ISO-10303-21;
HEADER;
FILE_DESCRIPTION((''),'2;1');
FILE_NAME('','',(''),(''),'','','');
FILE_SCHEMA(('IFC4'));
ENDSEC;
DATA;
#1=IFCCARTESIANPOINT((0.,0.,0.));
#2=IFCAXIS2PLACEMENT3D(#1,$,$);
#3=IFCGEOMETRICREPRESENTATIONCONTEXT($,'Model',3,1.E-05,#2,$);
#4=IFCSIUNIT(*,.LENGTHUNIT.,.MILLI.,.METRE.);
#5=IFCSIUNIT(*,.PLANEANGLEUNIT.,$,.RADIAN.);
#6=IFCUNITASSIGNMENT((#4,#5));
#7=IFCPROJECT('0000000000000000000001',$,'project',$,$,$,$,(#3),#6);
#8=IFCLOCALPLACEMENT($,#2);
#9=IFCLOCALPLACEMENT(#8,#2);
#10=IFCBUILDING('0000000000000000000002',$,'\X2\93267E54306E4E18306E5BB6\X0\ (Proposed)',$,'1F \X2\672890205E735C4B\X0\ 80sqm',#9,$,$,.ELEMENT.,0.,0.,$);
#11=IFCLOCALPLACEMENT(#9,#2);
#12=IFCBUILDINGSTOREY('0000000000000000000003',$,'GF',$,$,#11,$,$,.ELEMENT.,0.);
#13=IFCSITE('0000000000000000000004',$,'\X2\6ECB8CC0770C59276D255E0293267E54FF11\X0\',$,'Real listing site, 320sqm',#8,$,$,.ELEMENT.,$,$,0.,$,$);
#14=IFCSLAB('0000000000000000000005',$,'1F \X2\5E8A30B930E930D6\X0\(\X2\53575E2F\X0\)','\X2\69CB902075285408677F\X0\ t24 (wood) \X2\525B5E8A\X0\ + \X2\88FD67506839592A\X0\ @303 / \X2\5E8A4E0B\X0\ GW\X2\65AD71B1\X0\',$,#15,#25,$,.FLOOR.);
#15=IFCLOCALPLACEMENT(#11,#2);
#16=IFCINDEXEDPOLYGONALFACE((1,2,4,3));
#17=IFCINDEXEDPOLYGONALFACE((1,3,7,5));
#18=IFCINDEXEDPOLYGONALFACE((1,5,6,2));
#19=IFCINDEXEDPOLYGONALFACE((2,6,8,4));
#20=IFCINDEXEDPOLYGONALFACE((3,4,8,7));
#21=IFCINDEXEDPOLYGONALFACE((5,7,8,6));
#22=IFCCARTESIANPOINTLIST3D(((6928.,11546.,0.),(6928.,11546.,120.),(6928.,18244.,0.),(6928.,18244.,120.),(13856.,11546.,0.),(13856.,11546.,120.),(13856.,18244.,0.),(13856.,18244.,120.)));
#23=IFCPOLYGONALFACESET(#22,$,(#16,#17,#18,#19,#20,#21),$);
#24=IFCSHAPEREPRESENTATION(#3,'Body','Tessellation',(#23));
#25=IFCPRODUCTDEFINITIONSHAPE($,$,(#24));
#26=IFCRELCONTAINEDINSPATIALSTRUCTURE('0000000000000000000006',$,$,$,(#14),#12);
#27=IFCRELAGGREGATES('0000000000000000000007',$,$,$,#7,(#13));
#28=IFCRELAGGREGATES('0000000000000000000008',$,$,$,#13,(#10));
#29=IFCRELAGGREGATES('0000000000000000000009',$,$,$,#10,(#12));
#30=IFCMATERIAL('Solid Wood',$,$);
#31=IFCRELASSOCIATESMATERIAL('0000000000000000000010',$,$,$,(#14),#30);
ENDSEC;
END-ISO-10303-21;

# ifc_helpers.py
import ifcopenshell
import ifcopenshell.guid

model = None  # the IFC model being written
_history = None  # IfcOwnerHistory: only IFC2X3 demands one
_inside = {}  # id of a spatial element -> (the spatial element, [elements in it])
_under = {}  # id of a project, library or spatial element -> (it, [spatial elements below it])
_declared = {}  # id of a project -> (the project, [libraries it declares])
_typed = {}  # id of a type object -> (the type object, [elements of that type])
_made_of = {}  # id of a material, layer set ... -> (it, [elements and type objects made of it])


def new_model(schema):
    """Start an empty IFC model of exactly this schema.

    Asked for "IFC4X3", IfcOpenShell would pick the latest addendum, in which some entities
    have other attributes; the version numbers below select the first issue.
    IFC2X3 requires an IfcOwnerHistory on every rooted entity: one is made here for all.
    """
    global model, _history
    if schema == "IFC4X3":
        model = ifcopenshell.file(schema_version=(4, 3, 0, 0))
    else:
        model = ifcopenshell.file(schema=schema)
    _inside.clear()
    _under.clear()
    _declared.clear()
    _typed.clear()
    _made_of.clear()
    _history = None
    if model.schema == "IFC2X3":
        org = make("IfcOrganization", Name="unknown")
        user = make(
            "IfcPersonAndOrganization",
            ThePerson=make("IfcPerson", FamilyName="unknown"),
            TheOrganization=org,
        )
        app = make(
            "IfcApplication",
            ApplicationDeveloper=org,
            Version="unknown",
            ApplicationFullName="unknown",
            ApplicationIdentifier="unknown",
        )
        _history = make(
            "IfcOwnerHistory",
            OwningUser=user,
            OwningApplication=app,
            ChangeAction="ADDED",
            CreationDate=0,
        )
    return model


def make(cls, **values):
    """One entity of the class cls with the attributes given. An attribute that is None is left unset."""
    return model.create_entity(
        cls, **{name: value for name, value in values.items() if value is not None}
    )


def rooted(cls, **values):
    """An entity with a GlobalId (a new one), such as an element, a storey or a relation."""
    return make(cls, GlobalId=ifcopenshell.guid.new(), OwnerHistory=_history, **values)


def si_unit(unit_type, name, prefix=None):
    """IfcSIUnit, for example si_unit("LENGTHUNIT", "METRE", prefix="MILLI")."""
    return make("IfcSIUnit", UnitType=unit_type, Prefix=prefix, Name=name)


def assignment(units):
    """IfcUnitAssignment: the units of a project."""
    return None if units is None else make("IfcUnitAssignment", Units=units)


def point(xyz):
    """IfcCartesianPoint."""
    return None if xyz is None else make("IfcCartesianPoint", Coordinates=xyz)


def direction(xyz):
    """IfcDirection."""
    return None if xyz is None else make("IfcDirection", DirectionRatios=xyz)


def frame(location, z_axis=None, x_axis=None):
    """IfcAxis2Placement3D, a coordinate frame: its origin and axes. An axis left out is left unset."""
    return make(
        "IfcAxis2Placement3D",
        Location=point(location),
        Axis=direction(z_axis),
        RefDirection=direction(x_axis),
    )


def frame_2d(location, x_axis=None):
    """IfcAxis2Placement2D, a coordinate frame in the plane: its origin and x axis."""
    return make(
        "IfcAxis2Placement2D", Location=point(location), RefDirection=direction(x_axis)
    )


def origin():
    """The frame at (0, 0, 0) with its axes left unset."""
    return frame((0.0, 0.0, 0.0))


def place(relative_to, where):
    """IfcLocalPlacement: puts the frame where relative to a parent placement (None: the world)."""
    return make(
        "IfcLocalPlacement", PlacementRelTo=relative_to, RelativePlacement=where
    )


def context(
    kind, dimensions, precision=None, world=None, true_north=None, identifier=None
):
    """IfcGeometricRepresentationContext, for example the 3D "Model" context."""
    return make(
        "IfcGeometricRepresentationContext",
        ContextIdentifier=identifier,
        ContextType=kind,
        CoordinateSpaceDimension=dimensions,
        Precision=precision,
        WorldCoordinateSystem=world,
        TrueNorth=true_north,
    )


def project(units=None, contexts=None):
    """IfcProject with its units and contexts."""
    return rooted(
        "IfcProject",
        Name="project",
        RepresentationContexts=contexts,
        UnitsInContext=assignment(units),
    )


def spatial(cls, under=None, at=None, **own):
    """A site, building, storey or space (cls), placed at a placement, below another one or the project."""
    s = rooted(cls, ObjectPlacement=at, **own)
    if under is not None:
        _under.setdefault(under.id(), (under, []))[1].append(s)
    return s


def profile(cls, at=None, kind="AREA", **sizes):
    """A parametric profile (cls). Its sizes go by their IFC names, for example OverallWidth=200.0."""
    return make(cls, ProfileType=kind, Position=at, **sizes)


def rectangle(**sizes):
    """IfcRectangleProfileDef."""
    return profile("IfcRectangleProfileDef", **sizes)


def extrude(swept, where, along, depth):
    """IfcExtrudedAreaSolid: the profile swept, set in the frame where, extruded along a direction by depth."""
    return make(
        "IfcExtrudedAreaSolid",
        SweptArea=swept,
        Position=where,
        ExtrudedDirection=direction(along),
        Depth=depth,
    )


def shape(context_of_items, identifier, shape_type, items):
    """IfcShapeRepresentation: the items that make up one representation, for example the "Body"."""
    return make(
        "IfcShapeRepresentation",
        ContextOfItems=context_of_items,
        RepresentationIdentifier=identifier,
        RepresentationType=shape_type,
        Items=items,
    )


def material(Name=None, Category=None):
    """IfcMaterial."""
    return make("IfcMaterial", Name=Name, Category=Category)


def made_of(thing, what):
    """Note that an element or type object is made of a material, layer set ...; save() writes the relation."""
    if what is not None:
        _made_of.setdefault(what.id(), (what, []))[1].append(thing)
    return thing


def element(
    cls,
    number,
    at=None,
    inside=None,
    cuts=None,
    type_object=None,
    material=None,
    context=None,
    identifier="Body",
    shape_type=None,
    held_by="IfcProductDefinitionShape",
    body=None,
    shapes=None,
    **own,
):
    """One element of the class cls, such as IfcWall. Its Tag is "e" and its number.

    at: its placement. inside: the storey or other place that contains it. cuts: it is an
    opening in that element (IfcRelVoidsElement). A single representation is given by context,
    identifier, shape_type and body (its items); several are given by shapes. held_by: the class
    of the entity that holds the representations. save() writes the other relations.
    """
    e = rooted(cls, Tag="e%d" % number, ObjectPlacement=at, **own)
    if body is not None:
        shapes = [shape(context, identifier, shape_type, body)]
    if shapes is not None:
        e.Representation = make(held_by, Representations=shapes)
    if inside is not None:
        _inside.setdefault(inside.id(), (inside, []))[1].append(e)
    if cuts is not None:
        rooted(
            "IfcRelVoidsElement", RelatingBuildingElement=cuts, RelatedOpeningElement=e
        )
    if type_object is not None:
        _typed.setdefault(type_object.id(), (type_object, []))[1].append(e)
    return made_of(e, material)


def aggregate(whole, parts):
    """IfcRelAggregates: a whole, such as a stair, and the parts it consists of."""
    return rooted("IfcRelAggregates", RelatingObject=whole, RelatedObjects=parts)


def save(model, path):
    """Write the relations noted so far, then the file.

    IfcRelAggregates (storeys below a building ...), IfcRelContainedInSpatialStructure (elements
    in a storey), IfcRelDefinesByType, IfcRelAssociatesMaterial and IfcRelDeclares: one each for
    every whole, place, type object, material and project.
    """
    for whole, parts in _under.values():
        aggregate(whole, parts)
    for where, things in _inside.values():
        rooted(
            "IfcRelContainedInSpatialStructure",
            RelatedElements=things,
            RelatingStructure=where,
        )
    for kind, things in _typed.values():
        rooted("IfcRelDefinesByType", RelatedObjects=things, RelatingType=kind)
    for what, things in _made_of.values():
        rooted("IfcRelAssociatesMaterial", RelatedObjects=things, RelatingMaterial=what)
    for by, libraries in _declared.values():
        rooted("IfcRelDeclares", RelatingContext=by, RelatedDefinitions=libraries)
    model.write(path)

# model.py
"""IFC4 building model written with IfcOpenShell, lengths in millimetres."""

from ifc_helpers import new_model, si_unit, frame, frame_2d, origin, place, context, project, spatial, rectangle, extrude, material, element, save


model = new_model("IFC4")

# Units and contexts
model_context = context("Model", 3, precision=1e-05, world=origin())
ifc_project = project(units=[si_unit("LENGTHUNIT", "METRE", prefix="MILLI"), si_unit("PLANEANGLEUNIT", "RADIAN")], contexts=[model_context])

# Site, building, storey
site_placement = place(None, origin())
site = spatial("IfcSite", under=ifc_project, at=site_placement, Name="滋賀県大津市錦織１", ObjectType="Real listing site, 320sqm", CompositionType="ELEMENT", RefElevation=0.0)
building_placement = place(site_placement, origin())
building = spatial("IfcBuilding", under=site, at=building_placement, Name="錦織の丘の家 (Proposed)", ObjectType="1F 木造平屋 80sqm", CompositionType="ELEMENT", ElevationOfRefHeight=0.0, ElevationOfTerrain=0.0)
storey_placement = place(building_placement, origin())
storey = spatial("IfcBuildingStorey", under=building, at=storey_placement, Name="GF", CompositionType="ELEMENT", Elevation=0.0)

# Shared definitions
ifc_material_1 = material(Name="Solid Wood")

# Slab
slab_1_placement = place(storey_placement, frame((3464.0, 5773.0, 0.0)))
element("IfcSlab", 1, at=slab_1_placement, inside=storey, material=ifc_material_1, Name="1F 床スラブ(南帯)", Description="構造用合板 t24 (wood) 剛床 + 製材根太 @303 / 床下 GW断熱", PredefinedType="FLOOR", context=model_context, shape_type="SweptSolid", body=[
    extrude(rectangle(XDim=6928.0, YDim=6698.0, at=frame_2d((3464.0, 3349.0))), frame((3464.0, 5773.0, 0.0)), (0.0, 0.0, 1.0), 120.0),
])

save(model, "model.ifc")
